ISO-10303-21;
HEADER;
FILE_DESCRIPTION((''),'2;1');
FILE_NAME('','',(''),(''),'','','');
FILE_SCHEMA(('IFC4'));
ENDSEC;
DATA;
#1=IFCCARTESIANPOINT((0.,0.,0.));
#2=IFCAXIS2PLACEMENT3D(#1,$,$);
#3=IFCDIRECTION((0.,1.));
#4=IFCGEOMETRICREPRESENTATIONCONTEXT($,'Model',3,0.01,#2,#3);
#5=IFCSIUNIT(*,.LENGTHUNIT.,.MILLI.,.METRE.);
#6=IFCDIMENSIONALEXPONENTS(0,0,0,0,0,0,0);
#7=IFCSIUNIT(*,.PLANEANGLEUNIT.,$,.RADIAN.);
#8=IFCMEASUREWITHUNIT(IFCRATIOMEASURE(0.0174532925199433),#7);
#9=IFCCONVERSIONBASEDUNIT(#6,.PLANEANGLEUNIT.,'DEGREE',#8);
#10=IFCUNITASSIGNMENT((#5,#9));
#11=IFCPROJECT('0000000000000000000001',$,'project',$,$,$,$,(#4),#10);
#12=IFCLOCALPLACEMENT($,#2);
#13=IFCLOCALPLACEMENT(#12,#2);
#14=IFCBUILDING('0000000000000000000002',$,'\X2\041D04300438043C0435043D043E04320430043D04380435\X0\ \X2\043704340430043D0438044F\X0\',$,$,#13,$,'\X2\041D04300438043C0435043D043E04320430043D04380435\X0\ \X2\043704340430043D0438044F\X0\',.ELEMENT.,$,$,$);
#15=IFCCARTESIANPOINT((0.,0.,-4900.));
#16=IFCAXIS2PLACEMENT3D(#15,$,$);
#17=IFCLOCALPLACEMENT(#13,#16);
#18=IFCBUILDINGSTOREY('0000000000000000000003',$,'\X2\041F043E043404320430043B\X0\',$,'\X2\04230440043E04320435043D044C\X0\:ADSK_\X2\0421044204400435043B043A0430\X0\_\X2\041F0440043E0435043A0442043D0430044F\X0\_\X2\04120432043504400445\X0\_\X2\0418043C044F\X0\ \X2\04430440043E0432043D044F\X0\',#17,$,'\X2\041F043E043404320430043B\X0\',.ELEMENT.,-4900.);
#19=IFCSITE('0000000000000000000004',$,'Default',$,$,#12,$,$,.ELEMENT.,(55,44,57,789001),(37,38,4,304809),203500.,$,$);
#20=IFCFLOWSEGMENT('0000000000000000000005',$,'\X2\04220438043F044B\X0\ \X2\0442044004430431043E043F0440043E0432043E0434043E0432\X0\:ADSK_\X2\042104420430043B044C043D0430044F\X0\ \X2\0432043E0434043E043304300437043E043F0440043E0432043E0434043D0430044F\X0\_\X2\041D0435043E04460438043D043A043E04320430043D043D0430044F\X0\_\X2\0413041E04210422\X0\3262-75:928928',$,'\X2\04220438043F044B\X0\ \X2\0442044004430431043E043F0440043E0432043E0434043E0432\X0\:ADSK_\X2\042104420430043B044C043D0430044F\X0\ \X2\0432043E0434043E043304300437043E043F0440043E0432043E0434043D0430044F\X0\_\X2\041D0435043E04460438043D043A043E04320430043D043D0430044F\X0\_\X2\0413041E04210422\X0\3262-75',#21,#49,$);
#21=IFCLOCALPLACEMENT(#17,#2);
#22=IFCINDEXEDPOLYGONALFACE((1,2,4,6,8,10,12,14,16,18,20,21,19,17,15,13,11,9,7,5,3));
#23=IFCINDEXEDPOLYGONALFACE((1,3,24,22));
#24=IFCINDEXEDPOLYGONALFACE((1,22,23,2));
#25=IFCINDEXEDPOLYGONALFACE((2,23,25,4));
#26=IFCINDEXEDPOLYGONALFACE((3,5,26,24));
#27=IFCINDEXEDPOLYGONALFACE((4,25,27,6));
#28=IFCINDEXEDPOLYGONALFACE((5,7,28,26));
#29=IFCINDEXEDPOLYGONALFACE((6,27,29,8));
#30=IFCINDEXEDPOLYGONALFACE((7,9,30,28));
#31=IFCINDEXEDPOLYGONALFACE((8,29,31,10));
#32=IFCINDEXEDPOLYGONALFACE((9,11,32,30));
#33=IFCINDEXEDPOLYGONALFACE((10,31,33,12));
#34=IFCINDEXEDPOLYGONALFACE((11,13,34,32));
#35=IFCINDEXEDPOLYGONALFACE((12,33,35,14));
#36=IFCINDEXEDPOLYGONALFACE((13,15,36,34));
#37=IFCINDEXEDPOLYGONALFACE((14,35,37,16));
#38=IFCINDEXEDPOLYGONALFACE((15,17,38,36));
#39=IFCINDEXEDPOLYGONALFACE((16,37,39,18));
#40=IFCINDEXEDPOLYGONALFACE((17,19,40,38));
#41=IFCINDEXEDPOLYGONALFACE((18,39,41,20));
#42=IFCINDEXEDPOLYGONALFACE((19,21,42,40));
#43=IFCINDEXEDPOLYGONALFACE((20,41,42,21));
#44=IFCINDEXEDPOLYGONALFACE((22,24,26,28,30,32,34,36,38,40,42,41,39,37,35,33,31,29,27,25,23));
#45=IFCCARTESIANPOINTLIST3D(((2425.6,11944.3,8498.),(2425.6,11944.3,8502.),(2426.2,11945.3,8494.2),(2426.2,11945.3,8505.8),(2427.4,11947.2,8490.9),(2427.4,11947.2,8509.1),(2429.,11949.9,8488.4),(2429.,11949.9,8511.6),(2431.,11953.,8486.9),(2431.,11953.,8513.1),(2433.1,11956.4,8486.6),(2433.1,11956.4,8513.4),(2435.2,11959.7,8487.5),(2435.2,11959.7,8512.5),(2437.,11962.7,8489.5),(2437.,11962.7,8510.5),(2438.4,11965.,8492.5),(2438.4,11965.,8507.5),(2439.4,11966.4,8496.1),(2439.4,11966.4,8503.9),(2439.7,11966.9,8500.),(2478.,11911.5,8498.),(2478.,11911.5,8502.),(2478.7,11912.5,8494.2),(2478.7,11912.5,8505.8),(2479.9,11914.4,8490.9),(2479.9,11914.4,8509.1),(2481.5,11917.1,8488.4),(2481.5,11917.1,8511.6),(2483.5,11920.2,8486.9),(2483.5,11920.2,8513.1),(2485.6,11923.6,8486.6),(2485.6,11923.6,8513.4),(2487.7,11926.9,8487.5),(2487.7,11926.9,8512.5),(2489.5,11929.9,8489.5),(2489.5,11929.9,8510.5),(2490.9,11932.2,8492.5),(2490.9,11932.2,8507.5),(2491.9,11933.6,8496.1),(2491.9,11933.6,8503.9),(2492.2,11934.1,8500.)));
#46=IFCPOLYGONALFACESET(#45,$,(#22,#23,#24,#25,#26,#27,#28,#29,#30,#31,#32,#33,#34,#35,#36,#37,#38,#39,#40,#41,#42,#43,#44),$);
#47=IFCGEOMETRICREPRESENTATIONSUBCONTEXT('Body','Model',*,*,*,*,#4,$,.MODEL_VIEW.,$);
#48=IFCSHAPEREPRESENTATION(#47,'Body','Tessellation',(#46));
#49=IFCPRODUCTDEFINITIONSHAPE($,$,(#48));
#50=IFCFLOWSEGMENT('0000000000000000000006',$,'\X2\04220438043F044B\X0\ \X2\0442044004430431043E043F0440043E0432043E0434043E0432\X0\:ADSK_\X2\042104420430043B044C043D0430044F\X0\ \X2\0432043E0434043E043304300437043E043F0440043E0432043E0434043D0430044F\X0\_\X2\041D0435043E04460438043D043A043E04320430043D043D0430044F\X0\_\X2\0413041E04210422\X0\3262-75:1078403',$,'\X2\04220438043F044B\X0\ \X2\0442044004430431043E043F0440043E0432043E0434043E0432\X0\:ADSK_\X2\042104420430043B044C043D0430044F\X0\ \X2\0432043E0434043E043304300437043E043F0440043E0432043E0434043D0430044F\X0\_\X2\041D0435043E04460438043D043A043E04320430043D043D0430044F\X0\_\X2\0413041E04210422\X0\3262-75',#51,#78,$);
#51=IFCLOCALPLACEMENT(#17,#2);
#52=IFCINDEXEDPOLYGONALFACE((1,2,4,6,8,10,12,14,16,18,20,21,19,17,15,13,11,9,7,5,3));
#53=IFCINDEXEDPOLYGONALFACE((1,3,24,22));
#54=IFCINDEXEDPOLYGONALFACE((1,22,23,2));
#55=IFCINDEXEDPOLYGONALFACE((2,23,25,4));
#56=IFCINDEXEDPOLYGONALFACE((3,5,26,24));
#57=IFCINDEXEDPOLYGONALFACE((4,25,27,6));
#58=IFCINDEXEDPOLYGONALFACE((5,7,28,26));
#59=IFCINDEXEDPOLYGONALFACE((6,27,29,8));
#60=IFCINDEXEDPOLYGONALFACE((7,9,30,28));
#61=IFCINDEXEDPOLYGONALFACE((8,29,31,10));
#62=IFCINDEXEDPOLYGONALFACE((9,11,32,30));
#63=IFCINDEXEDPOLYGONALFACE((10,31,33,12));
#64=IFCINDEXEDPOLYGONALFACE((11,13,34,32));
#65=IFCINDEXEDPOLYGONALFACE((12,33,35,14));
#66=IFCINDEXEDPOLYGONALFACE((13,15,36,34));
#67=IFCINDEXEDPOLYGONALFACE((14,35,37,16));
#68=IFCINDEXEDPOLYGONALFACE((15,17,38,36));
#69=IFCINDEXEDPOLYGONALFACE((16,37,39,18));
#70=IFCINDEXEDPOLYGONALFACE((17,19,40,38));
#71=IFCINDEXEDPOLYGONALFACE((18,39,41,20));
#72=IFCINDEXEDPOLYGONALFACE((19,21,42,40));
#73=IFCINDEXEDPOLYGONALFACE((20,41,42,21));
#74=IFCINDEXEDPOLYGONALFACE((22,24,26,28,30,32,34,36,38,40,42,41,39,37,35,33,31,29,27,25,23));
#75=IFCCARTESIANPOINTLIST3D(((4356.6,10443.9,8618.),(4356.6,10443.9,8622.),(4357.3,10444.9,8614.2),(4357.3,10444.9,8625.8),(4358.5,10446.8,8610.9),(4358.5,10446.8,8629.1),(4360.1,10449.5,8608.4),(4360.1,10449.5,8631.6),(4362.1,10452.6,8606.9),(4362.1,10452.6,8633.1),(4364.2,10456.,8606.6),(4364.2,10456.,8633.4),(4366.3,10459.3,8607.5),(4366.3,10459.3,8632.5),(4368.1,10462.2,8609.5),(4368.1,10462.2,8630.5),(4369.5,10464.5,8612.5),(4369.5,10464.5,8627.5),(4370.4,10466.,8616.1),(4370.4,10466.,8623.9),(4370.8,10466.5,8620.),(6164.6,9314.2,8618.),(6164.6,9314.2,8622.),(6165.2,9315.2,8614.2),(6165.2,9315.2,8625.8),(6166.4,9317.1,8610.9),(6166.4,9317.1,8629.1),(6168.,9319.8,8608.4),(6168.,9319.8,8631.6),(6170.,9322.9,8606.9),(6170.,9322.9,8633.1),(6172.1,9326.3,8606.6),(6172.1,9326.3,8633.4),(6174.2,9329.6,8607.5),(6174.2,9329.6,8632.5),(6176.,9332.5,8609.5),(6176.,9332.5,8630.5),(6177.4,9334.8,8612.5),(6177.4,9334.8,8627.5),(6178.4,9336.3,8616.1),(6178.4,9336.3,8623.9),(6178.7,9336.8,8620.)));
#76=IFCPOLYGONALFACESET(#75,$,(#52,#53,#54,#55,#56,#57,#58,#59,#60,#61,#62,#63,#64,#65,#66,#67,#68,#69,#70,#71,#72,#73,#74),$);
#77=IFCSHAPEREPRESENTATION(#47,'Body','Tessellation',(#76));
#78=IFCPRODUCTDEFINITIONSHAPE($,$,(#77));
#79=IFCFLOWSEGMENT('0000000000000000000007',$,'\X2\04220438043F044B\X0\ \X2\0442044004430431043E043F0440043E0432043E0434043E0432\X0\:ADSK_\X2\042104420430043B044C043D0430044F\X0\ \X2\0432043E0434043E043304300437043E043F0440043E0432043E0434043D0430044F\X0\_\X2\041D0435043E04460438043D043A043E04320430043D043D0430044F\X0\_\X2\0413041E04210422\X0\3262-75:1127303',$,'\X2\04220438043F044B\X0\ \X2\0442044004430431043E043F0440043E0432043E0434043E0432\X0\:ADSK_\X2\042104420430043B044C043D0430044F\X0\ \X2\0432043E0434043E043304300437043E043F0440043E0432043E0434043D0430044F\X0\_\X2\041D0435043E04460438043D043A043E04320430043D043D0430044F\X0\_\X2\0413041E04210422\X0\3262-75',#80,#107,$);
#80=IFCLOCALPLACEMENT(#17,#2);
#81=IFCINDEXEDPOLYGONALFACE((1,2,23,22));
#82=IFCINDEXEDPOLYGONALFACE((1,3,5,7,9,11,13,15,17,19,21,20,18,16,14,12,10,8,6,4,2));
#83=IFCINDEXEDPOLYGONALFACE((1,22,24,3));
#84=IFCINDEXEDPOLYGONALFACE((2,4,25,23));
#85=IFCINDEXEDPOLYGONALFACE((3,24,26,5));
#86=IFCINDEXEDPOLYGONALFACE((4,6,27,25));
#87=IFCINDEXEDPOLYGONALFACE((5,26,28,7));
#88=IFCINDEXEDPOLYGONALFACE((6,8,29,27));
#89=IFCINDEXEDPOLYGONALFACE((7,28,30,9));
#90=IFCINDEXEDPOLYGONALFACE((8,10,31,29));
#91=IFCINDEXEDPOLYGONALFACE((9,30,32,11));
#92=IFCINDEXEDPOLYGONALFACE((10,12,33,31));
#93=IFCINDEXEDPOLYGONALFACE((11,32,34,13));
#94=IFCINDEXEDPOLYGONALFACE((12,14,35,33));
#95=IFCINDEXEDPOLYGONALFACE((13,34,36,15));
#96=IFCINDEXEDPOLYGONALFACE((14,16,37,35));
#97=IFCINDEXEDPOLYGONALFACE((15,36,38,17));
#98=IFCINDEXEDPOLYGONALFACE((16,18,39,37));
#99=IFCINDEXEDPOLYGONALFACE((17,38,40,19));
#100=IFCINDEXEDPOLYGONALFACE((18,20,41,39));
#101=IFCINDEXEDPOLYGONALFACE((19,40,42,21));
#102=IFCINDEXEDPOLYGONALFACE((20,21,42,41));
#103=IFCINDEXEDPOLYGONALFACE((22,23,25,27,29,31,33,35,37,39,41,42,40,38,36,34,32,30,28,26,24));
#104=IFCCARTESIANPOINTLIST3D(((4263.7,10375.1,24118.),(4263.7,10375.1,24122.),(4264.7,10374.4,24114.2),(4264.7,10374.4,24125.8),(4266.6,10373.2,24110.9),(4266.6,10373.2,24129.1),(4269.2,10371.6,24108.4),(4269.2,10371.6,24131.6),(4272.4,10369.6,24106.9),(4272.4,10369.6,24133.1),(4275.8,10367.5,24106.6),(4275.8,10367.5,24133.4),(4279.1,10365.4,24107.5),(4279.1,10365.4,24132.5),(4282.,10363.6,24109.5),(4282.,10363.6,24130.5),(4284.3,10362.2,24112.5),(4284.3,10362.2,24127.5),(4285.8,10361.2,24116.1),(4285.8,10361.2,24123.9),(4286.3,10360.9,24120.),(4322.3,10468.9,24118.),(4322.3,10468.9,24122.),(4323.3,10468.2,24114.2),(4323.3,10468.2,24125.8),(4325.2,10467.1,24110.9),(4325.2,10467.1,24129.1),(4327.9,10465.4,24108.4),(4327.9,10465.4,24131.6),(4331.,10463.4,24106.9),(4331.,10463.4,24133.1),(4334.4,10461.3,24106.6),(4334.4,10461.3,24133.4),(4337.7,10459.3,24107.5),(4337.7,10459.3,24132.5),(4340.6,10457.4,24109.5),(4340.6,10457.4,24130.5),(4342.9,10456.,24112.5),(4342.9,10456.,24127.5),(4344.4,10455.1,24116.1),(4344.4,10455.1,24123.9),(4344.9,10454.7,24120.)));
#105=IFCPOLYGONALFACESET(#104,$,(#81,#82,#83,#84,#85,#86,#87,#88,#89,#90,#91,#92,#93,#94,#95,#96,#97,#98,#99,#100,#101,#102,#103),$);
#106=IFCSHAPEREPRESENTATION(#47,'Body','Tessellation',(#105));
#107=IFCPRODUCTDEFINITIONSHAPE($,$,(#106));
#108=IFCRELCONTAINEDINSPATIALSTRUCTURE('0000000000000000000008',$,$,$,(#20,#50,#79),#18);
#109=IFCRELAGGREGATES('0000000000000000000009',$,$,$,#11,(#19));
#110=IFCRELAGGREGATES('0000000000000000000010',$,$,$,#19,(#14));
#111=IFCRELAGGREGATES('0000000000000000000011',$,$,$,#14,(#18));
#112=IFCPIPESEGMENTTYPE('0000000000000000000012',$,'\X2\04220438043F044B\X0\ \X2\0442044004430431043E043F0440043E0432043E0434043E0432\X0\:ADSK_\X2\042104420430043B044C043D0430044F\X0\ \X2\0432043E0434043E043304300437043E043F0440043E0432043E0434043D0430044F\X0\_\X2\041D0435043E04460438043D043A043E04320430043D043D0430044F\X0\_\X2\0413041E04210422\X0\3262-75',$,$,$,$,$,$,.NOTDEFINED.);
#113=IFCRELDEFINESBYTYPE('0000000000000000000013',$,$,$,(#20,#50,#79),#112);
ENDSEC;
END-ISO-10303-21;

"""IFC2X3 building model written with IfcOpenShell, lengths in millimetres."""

from ifc_helpers import new_model, entity, si_unit, converted_unit, direction, frame, origin, origin_2d_with_axis, place, context, subcontext, project, spatial, circle, extrude, type_object, element, save


model = new_model("IFC2X3")

# Units and contexts
model_context = context("Model", 3, precision=0.01, world=origin(), true_north=direction((0.0, 1.0)))
body_context = subcontext(model_context, "Body", "Model", "MODEL_VIEW")
ifc_project = project(units=[si_unit("LENGTHUNIT", "METRE", prefix="MILLI"), converted_unit("PLANEANGLEUNIT", "DEGREE", entity("IfcRatioMeasure", 0.0174532925199433), si_unit("PLANEANGLEUNIT", "RADIAN"), dimensions=[0, 0, 0, 0, 0, 0, 0])], contexts=[model_context])

# Site, building, storey
site_placement = place(None, origin())
site = spatial("IfcSite", under=ifc_project, at=site_placement, Name="Default", CompositionType="ELEMENT", RefLatitude=(55, 44, 57, 789001), RefLongitude=(37, 38, 4, 304809), RefElevation=203500.0)
building_placement = place(site_placement, origin())
building = spatial("IfcBuilding", under=site, at=building_placement, Name="Наименование здания", LongName="Наименование здания", CompositionType="ELEMENT")
storey_placement = place(building_placement, frame((0.0, 0.0, -4900.0)))
storey = spatial("IfcBuildingStorey", under=building, at=storey_placement, Name="Подвал", ObjectType="Уровень:ADSK_Стрелка_Проектная_Вверх_Имя уровня", LongName="Подвал", CompositionType="ELEMENT", Elevation=-4900.0)

# Flow segments
pipe_segment_type = type_object("IfcPipeSegmentType", Name="Типы трубопроводов:ADSK_Стальная водогазопроводная_Неоцинкованная_ГОСТ3262-75", PredefinedType="NOTDEFINED")
flow_segment_1_placement = place(storey_placement, frame((2423.9, 11909.8, 8485.0)))
element("IfcFlowSegment", 1, at=flow_segment_1_placement, inside=storey, type_object=pipe_segment_type, Name="Типы трубопроводов:ADSK_Стальная водогазопроводная_Неоцинкованная_ГОСТ3262-75:928928", ObjectType="Типы трубопроводов:ADSK_Стальная водогазопроводная_Неоцинкованная_ГОСТ3262-75", context=body_context, shape_type="SweptSolid", body=[
    extrude(circle(Radius=13.4, at=origin_2d_with_axis()), frame((61.2, 13.0, 15.0), z_axis=(-0.848053, 0.529912, 0.0), x_axis=(0.529912, 0.848053, 0.0)), (0.0, 0.0, 1.0), 61.9),
])
flow_segment_2_placement = place(storey_placement, frame((4355.0, 9312.5, 8605.0)))
element("IfcFlowSegment", 2, at=flow_segment_2_placement, inside=storey, type_object=pipe_segment_type, Name="Типы трубопроводов:ADSK_Стальная водогазопроводная_Неоцинкованная_ГОСТ3262-75:1078403", ObjectType="Типы трубопроводов:ADSK_Стальная водогазопроводная_Неоцинкованная_ГОСТ3262-75", context=body_context, shape_type="SweptSolid", body=[
    extrude(circle(Radius=13.4, at=origin_2d_with_axis()), frame((1816.6, 13.0, 15.0), z_axis=(-0.848053, 0.529912, 0.0), x_axis=(0.529912, 0.848053, 0.0)), (0.0, 0.0, 1.0), 2131.9),
])
flow_segment_3_placement = place(storey_placement, frame((4261.9, 10359.3, 24105.0)))
element("IfcFlowSegment", 3, at=flow_segment_3_placement, inside=storey, type_object=pipe_segment_type, Name="Типы трубопроводов:ADSK_Стальная водогазопроводная_Неоцинкованная_ГОСТ3262-75:1127303", ObjectType="Типы трубопроводов:ADSK_Стальная водогазопроводная_Неоцинкованная_ГОСТ3262-75", context=body_context, shape_type="SweptSolid", body=[
    extrude(circle(Radius=13.4, at=origin_2d_with_axis()), frame((13.0, 8.7, 15.0), z_axis=(0.529912, 0.848053, 0.0), x_axis=(0.848053, -0.529912, 0.0)), (0.0, 0.0, 1.0), 110.6),
])

save(model, "model.ifc")
